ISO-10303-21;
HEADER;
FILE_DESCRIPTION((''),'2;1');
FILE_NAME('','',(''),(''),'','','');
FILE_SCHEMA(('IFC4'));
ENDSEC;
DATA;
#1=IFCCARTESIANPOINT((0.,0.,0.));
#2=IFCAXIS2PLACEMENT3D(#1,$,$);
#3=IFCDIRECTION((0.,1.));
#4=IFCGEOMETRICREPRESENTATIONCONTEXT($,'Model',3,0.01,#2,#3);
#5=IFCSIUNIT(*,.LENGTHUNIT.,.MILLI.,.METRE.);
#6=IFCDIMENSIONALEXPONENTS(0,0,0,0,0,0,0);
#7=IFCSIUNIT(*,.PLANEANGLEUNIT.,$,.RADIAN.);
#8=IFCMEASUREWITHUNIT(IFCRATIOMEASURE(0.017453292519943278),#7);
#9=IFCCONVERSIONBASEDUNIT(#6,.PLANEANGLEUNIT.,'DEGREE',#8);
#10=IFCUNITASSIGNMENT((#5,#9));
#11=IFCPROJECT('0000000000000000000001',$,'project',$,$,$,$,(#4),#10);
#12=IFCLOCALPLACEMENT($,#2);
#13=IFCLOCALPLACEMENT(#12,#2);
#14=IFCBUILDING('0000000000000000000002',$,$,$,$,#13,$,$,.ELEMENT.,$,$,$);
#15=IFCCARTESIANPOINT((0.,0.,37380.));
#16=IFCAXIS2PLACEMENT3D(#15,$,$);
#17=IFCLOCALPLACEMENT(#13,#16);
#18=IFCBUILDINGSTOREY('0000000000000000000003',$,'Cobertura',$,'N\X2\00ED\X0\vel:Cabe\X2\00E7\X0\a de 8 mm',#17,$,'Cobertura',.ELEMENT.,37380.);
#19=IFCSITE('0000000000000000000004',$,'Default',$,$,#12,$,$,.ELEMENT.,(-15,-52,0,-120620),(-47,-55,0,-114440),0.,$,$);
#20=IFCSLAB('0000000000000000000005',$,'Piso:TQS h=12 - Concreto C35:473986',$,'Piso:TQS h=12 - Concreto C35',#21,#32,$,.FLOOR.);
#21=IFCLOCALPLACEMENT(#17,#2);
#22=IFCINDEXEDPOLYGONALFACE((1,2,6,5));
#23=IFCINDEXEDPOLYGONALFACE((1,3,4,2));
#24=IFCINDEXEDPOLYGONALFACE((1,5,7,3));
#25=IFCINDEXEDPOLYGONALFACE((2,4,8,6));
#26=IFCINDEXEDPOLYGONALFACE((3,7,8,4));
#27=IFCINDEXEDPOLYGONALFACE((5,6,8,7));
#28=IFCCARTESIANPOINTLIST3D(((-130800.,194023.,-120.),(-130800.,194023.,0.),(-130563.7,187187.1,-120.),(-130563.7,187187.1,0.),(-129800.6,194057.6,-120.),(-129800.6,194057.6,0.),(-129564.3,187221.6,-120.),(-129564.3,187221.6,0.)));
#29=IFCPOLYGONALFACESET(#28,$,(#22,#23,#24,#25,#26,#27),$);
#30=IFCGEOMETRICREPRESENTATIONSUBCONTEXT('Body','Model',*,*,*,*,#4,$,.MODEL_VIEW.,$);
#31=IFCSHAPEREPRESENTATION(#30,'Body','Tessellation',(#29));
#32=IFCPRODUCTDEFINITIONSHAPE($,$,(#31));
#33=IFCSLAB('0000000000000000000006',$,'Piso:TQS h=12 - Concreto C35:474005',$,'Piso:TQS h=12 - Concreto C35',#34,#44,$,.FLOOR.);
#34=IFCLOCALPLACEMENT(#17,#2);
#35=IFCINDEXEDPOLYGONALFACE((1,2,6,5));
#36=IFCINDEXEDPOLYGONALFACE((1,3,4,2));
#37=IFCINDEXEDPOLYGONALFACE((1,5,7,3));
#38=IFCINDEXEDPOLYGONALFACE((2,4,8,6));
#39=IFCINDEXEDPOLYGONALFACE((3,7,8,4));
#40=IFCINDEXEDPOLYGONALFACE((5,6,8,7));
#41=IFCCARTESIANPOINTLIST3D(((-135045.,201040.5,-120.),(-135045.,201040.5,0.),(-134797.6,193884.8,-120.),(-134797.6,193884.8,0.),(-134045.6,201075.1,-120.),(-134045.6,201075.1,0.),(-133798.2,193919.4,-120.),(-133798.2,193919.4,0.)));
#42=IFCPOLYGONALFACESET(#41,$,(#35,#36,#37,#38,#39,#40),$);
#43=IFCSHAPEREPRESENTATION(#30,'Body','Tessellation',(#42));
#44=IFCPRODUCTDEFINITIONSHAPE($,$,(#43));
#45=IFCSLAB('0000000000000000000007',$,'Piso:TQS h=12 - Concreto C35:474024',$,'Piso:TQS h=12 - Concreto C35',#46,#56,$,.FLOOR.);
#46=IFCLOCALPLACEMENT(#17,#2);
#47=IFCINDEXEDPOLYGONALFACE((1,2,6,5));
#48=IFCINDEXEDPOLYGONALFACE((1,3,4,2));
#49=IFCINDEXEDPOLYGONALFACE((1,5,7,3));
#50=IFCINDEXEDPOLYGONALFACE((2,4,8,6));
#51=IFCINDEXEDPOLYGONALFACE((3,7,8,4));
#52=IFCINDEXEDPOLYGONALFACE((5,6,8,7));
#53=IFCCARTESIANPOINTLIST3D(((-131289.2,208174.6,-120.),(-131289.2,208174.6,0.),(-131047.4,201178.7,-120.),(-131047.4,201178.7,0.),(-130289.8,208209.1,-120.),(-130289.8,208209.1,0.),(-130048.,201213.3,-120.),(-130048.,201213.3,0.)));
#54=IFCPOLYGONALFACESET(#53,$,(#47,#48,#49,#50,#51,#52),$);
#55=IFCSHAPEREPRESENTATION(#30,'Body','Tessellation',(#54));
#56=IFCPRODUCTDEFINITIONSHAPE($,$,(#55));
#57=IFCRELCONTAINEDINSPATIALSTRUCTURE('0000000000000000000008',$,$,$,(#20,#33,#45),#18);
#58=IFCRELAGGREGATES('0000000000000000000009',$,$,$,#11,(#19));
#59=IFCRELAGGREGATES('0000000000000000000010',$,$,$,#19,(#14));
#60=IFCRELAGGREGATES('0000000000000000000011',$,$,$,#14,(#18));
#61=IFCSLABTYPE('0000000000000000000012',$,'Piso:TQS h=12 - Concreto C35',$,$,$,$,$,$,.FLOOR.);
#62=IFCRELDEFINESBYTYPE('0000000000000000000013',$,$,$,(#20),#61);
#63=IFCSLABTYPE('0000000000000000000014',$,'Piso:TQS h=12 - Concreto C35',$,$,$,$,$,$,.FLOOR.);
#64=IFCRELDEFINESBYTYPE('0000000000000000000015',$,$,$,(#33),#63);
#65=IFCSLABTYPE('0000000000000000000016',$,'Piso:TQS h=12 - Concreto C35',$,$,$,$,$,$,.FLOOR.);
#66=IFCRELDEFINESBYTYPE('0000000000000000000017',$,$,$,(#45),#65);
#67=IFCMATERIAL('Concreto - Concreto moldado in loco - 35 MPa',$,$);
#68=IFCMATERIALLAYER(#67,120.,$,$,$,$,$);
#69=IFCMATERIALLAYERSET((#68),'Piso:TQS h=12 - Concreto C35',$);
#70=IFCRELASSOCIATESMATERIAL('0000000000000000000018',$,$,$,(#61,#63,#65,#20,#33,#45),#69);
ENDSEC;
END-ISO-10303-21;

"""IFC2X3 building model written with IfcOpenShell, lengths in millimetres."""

from ifc_helpers import new_model, entity, si_unit, converted_unit, direction, frame, frame_2d, origin, place, context, subcontext, project, spatial, rectangle, extrude, material, layer, layer_set, layer_usage, type_object, element, save


model = new_model("IFC2X3")

# Units and contexts
model_context = context("Model", 3, precision=0.01, world=origin(), true_north=direction((0.0, 1.0)))
body_context = subcontext(model_context, "Body", "Model", "MODEL_VIEW")
ifc_project = project(units=[si_unit("LENGTHUNIT", "METRE", prefix="MILLI"), converted_unit("PLANEANGLEUNIT", "DEGREE", entity("IfcRatioMeasure", 0.017453292519943278), si_unit("PLANEANGLEUNIT", "RADIAN"), dimensions=[0, 0, 0, 0, 0, 0, 0])], contexts=[model_context])

# Site, building, storey
site_placement = place(None, origin())
site = spatial("IfcSite", under=ifc_project, at=site_placement, Name="Default", CompositionType="ELEMENT", RefLatitude=(-15, -52, 0, -120620), RefLongitude=(-47, -55, 0, -114440), RefElevation=0.0)
building_placement = place(site_placement, origin())
building = spatial("IfcBuilding", under=site, at=building_placement, CompositionType="ELEMENT")
storey_placement = place(building_placement, frame((0.0, 0.0, 37380.0)))
storey = spatial("IfcBuildingStorey", under=building, at=storey_placement, Name="Cobertura", ObjectType="Nível:Cabeça de 8 mm", LongName="Cobertura", CompositionType="ELEMENT", Elevation=37380.0)

# Shared definitions
ifc_material = material(Name="Concreto - Concreto moldado in loco - 35 MPa")

# Slabs
ifc_layer_1 = layer(ifc_material, 120.0)
ifc_layer_set_1 = layer_set([ifc_layer_1], Name="Piso:TQS h=12 - Concreto C35")
ifc_layer_usage_1 = layer_usage(ifc_layer_set_1, "AXIS3", "POSITIVE", 0.0)
slab_type_1 = type_object("IfcSlabType", Name="Piso:TQS h=12 - Concreto C35", PredefinedType="FLOOR", material=ifc_layer_set_1)
slab_1_placement = place(storey_placement, origin())
element("IfcSlab", 1, at=slab_1_placement, inside=storey, type_object=slab_type_1, material=ifc_layer_usage_1, Name="Piso:TQS h=12 - Concreto C35:473986", ObjectType="Piso:TQS h=12 - Concreto C35", PredefinedType="FLOOR", context=body_context, shape_type="SweptSolid", body=[
    extrude(rectangle(XDim=6840.0, YDim=1000.0, at=frame_2d((0.0, 0.0), x_axis=(1.0, 0.0))), frame((-130182.1, 190622.3, 0.0), z_axis=(0.0, 0.0, -1.0), x_axis=(0.034551, -0.999403, 0.0)), (0.0, 0.0, 1.0), 120.0),
])
ifc_layer_usage_2 = layer_usage(ifc_layer_set_1, "AXIS3", "POSITIVE", 0.0)
slab_type_2 = type_object("IfcSlabType", Name="Piso:TQS h=12 - Concreto C35", PredefinedType="FLOOR", material=ifc_layer_set_1)
slab_2_placement = place(storey_placement, origin())
element("IfcSlab", 2, at=slab_2_placement, inside=storey, type_object=slab_type_2, material=ifc_layer_usage_2, Name="Piso:TQS h=12 - Concreto C35:474005", ObjectType="Piso:TQS h=12 - Concreto C35", PredefinedType="FLOOR", context=body_context, shape_type="SweptSolid", body=[
    extrude(rectangle(XDim=7160.0, YDim=1000.0, at=frame_2d((0.0, 0.0), x_axis=(1.0, 0.0))), frame((-134421.6, 197479.9, 0.0), z_axis=(0.0, 0.0, -1.0), x_axis=(0.034551, -0.999403, 0.0)), (0.0, 0.0, 1.0), 120.0),
])
ifc_layer_usage_3 = layer_usage(ifc_layer_set_1, "AXIS3", "POSITIVE", 0.0)
slab_type_3 = type_object("IfcSlabType", Name="Piso:TQS h=12 - Concreto C35", PredefinedType="FLOOR", material=ifc_layer_set_1)
slab_3_placement = place(storey_placement, origin())
element("IfcSlab", 3, at=slab_3_placement, inside=storey, type_object=slab_type_3, material=ifc_layer_usage_3, Name="Piso:TQS h=12 - Concreto C35:474024", ObjectType="Piso:TQS h=12 - Concreto C35", PredefinedType="FLOOR", context=body_context, shape_type="SweptSolid", body=[
    extrude(rectangle(XDim=7000.0, YDim=1000.0, at=frame_2d((0.0, 0.0), x_axis=(1.0, 0.0))), frame((-130668.6, 204693.9, 0.0), z_axis=(0.0, 0.0, -1.0), x_axis=(0.034551, -0.999403, 0.0)), (0.0, 0.0, 1.0), 120.0),
])

save(model, "model.ifc")
